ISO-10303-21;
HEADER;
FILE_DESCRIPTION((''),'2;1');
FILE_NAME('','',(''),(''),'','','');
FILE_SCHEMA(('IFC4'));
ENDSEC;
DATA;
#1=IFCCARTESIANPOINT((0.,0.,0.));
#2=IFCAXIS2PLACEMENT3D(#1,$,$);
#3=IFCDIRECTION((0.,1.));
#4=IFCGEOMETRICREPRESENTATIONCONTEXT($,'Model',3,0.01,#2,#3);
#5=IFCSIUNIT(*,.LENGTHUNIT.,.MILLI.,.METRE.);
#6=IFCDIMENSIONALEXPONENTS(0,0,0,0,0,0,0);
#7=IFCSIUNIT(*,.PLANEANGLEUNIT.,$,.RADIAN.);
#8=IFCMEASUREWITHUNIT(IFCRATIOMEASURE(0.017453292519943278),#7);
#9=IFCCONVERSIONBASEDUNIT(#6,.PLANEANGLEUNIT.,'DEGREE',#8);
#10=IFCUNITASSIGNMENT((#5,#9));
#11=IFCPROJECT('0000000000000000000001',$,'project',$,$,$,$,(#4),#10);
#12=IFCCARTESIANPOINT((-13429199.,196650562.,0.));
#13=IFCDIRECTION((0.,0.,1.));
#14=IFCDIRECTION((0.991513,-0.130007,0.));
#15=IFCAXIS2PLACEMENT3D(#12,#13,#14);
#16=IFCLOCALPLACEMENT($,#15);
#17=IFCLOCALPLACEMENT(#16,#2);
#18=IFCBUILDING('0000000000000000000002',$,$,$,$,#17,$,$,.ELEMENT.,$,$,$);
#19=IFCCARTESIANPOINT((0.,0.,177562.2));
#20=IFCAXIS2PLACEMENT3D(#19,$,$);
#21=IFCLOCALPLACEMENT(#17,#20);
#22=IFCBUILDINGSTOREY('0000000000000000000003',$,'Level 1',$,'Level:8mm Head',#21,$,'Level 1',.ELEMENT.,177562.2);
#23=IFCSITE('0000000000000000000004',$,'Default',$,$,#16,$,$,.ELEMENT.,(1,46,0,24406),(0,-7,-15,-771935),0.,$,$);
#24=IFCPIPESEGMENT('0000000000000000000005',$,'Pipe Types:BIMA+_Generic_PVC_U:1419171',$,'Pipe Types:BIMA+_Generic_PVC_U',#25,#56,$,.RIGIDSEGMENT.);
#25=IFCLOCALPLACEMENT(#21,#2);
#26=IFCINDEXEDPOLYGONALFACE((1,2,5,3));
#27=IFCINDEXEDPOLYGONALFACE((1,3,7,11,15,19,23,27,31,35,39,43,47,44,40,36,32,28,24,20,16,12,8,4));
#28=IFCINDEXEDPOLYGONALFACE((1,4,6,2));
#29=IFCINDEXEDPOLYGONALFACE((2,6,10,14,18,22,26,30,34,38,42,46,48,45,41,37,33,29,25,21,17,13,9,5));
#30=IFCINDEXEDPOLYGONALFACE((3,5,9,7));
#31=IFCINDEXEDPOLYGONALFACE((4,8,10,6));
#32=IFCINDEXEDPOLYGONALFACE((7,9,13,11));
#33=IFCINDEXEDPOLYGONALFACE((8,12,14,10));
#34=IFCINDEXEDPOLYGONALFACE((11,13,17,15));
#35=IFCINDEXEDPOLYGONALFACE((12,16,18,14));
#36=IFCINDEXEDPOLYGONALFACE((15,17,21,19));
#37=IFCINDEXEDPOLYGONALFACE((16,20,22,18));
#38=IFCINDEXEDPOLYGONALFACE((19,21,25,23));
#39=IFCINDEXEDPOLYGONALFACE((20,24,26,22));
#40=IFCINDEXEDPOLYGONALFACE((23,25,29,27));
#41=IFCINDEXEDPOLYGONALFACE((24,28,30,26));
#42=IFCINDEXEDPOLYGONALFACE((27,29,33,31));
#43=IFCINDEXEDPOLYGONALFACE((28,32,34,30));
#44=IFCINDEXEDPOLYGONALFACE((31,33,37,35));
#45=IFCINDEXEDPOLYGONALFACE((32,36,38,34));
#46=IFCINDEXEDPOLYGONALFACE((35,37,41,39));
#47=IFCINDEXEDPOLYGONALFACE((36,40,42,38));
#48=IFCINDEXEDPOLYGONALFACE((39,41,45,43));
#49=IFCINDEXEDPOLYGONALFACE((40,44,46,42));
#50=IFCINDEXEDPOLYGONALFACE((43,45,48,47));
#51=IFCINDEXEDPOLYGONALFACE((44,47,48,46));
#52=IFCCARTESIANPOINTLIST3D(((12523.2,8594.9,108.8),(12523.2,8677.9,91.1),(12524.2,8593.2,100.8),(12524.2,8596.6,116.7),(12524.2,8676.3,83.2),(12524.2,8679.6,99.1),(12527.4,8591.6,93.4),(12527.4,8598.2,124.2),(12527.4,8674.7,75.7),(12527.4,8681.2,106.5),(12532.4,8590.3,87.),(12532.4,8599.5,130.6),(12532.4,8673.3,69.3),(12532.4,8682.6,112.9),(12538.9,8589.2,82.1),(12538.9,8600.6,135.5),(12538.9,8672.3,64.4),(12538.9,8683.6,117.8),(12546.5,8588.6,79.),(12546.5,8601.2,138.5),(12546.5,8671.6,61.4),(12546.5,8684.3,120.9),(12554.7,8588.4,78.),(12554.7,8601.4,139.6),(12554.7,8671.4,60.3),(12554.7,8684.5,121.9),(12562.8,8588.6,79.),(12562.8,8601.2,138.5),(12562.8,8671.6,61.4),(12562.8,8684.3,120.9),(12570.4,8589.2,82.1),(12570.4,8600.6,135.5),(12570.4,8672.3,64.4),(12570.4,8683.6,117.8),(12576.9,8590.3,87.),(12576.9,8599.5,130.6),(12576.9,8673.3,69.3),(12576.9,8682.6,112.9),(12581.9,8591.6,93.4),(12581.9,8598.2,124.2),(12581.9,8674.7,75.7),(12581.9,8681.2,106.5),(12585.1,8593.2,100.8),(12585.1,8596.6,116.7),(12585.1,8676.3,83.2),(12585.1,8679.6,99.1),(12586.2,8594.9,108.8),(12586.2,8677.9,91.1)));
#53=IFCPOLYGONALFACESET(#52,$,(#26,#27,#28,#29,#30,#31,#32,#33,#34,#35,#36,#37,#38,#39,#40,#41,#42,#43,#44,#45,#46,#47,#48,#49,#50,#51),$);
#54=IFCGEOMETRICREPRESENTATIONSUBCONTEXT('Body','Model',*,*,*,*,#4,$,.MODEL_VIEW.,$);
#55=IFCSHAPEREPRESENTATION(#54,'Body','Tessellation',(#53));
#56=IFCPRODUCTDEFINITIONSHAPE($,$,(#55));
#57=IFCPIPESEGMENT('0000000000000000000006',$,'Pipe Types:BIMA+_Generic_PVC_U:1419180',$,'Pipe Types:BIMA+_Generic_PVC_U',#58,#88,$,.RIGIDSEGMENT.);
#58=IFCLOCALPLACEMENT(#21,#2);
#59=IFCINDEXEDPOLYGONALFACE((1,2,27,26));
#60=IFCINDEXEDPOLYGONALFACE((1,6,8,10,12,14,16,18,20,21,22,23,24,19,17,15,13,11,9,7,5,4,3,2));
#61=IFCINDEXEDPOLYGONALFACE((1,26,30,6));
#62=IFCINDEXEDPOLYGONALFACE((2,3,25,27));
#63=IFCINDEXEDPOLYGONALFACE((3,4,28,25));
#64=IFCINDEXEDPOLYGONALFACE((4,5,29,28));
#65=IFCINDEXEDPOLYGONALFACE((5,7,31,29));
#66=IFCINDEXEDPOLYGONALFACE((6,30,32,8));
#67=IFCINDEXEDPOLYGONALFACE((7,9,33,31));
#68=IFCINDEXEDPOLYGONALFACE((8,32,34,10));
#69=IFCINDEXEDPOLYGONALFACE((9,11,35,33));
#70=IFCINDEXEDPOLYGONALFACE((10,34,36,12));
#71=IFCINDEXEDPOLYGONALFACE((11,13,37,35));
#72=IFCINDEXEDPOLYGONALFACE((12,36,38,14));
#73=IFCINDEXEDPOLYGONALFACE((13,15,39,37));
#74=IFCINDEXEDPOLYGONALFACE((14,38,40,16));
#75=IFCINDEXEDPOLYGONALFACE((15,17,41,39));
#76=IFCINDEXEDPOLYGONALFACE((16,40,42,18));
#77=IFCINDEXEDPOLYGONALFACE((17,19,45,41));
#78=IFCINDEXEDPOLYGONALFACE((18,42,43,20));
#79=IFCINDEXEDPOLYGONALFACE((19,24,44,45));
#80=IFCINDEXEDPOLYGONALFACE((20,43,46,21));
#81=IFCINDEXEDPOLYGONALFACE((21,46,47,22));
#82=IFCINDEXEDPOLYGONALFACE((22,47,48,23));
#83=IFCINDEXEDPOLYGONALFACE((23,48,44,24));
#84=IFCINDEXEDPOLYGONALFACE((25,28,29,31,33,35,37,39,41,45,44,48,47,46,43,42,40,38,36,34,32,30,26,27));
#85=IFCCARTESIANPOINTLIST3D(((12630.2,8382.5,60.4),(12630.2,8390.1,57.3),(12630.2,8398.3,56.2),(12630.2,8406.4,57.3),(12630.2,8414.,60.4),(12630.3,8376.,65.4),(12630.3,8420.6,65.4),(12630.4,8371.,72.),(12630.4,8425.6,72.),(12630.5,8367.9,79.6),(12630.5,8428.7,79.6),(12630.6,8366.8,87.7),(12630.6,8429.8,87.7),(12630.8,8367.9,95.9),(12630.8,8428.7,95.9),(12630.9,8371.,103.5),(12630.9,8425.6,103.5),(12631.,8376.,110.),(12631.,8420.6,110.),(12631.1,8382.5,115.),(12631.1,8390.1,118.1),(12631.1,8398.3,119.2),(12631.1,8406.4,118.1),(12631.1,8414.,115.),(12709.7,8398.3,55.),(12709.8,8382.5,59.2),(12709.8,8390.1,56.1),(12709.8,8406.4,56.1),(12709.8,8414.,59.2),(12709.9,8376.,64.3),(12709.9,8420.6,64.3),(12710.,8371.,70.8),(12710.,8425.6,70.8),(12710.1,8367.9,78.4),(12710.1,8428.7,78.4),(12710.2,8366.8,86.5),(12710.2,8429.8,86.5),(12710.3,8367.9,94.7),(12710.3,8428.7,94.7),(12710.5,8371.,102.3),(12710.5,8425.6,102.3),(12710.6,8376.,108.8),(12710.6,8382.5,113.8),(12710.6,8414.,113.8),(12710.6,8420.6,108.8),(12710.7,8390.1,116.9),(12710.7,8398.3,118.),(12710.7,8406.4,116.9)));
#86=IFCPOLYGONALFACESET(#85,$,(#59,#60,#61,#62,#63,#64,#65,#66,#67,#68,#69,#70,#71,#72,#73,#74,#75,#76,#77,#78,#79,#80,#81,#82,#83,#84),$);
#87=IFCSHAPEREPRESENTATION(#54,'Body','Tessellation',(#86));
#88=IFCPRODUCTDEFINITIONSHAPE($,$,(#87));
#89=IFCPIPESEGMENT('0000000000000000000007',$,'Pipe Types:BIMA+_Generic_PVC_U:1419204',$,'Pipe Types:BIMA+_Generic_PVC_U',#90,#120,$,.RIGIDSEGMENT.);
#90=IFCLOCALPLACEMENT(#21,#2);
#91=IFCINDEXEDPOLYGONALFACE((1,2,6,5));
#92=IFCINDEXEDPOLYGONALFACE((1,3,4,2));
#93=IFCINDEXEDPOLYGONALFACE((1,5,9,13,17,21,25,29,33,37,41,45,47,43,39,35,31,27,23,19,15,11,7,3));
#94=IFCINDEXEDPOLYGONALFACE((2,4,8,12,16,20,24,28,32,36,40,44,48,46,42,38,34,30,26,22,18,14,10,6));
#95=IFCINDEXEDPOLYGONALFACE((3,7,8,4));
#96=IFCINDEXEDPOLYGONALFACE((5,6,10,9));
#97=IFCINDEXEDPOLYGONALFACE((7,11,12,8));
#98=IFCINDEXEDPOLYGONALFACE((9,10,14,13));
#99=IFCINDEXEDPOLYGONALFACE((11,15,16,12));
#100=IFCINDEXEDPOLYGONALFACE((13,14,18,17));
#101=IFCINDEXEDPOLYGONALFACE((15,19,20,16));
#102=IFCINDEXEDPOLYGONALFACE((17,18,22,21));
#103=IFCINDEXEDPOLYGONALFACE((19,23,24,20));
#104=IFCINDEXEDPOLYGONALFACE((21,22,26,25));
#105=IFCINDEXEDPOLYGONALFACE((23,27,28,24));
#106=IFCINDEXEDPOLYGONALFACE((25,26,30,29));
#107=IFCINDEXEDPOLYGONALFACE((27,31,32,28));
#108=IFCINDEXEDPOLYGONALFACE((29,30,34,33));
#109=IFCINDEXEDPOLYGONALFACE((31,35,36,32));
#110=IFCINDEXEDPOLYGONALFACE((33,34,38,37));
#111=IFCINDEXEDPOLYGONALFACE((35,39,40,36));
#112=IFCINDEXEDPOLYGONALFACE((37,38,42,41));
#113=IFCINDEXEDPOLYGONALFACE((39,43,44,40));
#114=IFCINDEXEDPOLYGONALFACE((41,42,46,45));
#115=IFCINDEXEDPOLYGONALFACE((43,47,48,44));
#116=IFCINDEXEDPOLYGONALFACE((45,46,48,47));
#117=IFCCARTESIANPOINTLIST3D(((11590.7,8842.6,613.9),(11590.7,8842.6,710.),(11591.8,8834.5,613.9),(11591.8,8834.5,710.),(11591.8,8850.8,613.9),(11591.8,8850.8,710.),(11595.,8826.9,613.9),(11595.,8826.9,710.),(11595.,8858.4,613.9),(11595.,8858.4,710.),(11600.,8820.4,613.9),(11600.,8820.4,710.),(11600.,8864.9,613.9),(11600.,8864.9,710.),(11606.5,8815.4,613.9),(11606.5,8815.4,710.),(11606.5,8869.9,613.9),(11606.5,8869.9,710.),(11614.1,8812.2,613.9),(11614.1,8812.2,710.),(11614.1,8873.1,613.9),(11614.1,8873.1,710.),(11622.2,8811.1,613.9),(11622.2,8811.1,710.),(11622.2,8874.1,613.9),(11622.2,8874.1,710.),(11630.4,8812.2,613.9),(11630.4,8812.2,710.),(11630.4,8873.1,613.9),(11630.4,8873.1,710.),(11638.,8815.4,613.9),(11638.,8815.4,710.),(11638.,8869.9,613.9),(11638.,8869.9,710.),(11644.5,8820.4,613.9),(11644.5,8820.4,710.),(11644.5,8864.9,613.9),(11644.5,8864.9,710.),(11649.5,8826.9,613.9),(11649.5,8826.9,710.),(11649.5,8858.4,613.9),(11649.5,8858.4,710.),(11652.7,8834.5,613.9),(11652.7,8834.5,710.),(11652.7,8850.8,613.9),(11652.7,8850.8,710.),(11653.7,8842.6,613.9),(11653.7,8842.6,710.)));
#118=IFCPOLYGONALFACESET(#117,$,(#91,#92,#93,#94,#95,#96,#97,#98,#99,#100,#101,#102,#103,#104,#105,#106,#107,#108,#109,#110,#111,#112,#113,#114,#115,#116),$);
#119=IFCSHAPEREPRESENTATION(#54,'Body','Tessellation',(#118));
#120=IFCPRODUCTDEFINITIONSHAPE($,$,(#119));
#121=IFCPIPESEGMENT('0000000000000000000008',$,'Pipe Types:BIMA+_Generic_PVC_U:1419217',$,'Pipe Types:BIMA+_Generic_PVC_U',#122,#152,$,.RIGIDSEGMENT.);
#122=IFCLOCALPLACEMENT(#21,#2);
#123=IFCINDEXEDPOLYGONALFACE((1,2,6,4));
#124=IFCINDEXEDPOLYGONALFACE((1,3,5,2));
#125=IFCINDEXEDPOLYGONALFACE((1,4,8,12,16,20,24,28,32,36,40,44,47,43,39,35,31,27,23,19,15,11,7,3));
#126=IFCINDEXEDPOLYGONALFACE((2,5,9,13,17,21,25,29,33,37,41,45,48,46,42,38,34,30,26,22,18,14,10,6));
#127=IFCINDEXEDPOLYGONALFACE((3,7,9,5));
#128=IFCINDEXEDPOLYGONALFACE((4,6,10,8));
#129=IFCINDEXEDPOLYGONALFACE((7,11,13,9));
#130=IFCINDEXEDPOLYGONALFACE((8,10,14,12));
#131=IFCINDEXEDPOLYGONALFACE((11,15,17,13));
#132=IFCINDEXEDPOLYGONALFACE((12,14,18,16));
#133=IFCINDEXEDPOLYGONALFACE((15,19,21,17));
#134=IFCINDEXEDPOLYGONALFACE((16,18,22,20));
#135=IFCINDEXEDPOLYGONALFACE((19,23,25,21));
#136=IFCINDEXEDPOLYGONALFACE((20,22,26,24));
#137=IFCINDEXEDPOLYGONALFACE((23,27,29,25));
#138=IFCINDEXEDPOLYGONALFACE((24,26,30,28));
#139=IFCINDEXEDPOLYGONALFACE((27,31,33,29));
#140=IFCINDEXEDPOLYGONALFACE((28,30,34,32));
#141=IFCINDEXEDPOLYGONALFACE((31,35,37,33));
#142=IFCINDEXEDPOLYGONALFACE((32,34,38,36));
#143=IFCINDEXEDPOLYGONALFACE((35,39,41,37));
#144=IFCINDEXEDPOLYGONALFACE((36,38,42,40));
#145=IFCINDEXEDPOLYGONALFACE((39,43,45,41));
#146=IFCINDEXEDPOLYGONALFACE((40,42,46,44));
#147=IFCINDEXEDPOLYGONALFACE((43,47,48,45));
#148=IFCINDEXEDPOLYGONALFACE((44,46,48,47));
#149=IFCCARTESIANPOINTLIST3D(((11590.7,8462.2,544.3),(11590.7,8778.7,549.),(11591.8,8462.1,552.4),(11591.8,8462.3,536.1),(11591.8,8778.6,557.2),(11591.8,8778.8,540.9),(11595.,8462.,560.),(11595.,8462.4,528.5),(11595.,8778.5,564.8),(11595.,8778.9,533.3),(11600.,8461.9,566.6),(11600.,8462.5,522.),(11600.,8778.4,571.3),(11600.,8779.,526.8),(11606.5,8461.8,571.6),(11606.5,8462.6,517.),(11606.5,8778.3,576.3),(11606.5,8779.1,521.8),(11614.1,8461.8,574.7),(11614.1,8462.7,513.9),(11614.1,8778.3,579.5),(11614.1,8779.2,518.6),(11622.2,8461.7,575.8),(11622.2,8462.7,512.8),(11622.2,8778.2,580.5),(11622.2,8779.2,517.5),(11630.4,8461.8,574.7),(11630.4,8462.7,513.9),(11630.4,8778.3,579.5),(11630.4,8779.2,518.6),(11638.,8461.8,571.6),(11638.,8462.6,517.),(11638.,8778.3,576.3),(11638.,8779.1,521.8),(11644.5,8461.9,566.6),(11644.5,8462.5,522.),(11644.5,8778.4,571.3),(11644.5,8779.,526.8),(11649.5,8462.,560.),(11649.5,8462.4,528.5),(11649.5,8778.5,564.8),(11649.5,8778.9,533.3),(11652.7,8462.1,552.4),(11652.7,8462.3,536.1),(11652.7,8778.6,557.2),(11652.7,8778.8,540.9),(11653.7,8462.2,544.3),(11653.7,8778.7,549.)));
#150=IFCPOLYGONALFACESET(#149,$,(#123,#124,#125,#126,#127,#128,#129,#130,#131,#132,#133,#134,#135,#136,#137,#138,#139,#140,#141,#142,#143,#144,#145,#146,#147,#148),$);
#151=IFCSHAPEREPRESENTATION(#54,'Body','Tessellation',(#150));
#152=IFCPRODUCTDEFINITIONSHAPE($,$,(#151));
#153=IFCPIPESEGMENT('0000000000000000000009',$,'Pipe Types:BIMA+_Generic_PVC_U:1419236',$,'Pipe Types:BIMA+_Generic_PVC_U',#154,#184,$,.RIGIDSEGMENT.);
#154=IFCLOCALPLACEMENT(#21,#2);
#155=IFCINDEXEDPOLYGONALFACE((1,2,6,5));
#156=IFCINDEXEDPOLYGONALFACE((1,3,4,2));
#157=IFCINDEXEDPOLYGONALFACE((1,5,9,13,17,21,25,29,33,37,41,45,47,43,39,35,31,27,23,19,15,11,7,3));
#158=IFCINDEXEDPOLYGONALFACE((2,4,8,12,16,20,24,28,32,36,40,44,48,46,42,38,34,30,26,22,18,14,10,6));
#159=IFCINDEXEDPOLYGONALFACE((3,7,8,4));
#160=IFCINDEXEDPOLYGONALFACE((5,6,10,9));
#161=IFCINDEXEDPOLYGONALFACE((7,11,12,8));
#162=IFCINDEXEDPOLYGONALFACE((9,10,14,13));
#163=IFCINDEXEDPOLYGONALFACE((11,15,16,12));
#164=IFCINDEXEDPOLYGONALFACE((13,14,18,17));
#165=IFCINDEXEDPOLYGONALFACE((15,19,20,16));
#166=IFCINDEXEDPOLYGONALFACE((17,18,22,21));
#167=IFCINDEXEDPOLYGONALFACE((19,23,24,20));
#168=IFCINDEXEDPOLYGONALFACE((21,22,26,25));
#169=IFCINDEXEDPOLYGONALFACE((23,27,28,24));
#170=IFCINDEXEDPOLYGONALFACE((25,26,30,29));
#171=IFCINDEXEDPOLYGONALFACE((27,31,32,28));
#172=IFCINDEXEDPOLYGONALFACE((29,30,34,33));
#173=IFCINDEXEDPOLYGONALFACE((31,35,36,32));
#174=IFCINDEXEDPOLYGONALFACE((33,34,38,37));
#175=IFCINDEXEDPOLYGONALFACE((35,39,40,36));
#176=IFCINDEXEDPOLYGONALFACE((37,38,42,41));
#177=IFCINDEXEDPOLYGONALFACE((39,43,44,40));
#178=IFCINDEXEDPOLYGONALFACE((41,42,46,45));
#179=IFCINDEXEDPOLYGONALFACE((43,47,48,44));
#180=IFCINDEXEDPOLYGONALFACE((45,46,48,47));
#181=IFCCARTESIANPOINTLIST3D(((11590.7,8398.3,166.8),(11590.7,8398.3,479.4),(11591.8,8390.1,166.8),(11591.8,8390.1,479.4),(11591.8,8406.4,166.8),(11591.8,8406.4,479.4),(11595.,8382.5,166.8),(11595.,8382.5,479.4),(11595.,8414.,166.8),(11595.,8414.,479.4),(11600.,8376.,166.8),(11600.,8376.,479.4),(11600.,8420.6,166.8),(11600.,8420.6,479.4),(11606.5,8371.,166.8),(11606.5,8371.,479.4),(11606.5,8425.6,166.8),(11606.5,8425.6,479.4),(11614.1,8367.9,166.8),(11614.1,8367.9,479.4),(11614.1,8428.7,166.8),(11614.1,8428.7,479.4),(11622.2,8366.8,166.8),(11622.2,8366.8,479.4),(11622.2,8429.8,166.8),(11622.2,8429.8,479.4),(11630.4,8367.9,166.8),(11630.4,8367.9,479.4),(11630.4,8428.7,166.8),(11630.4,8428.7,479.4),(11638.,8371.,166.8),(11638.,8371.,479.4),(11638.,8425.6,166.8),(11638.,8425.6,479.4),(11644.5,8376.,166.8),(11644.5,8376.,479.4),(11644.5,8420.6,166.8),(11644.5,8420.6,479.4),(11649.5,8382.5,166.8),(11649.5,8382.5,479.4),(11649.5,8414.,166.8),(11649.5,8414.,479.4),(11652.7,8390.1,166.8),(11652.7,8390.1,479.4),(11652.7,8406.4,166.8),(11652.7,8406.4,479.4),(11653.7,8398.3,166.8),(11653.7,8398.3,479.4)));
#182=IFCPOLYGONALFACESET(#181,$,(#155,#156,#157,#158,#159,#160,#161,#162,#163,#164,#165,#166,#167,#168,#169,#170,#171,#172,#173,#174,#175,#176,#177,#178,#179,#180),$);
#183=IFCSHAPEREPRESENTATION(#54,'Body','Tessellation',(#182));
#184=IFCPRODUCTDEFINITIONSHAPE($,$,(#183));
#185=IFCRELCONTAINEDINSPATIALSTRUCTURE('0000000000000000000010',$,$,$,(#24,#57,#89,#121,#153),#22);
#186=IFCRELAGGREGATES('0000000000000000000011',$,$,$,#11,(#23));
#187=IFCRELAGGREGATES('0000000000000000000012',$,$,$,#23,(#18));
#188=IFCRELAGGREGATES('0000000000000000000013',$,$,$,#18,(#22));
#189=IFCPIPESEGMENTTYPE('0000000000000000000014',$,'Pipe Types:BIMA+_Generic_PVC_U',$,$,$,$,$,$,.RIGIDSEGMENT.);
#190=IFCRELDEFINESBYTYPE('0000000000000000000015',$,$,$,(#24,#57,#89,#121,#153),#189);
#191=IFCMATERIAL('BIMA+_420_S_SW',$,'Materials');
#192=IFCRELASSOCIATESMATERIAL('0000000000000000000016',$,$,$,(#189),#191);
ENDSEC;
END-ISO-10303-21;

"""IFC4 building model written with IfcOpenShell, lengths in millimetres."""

from ifc_helpers import new_model, entity, si_unit, converted_unit, direction, frame, origin, place, context, subcontext, project, spatial, arc, indexed_curve, outline, extrude, material, type_object, element, save


model = new_model("IFC4")

# Units and contexts
model_context = context("Model", 3, precision=0.01, world=origin(), true_north=direction((0.0, 1.0)))
body_context = subcontext(model_context, "Body", "Model", "MODEL_VIEW")
ifc_project = project(units=[si_unit("LENGTHUNIT", "METRE", prefix="MILLI"), converted_unit("PLANEANGLEUNIT", "DEGREE", entity("IfcRatioMeasure", 0.017453292519943278), si_unit("PLANEANGLEUNIT", "RADIAN"), dimensions=[0, 0, 0, 0, 0, 0, 0])], contexts=[model_context])

# Site, building, storey
site_placement = place(None, frame((-13429199.0, 196650562.0, 0.0), z_axis=(0.0, 0.0, 1.0), x_axis=(0.991513, -0.130007, 0.0)))
site = spatial("IfcSite", under=ifc_project, at=site_placement, Name="Default", CompositionType="ELEMENT", RefLatitude=(1, 46, 0, 24406), RefLongitude=(0, -7, -15, -771935), RefElevation=0.0)
building_placement = place(site_placement, origin())
building = spatial("IfcBuilding", under=site, at=building_placement, CompositionType="ELEMENT")
storey_placement = place(building_placement, frame((0.0, 0.0, 177562.2)))
storey = spatial("IfcBuildingStorey", under=building, at=storey_placement, Name="Level 1", ObjectType="Level:8mm Head", LongName="Level 1", CompositionType="ELEMENT", Elevation=177562.2)

# Pipe segments
ifc_material_1 = material(Name="BIMA+_420_S_SW", Category="Materials")
pipe_segment_type_1 = type_object("IfcPipeSegmentType", Name="Pipe Types:BIMA+_Generic_PVC_U", PredefinedType="RIGIDSEGMENT", material=ifc_material_1)
pipe_segment_1_placement = place(storey_placement, frame((12521.6, 8586.8, 141.2)))
element("IfcPipeSegment", 1, at=pipe_segment_1_placement, inside=storey, type_object=pipe_segment_type_1, Name="Pipe Types:BIMA+_Generic_PVC_U:1419171", ObjectType="Pipe Types:BIMA+_Generic_PVC_U", PredefinedType="RIGIDSEGMENT", context=body_context, shape_type="SweptSolid", body=[
    extrude(outline(indexed_curve([(31.5, 0.0), (22.3, 22.3), (0.0, 31.5), (-22.3, 22.3), (-31.5, 0.0), (-22.3, -22.3), (0.0, -31.5), (22.3, -22.3)], segments=[arc(1, 2, 3), arc(3, 4, 5), arc(5, 6, 7), arc(7, 8, 1)], self_intersect=False)), frame((33.1, 91.2, -50.0), z_axis=(-0.000061, -0.978185, 0.207737), x_axis=(-1.0, 0.000062, 0.0)), (0.0, 0.0, 1.0), 84.9),
])
pipe_segment_2_placement = place(storey_placement, frame((12628.6, 8365.2, 120.8)))
element("IfcPipeSegment", 2, at=pipe_segment_2_placement, inside=storey, type_object=pipe_segment_type_1, Name="Pipe Types:BIMA+_Generic_PVC_U:1419180", ObjectType="Pipe Types:BIMA+_Generic_PVC_U", PredefinedType="RIGIDSEGMENT", context=body_context, shape_type="SweptSolid", body=[
    extrude(outline(indexed_curve([(31.5, 0.0), (22.3, 22.3), (0.0, 31.5), (-22.3, 22.3), (-31.5, 0.0), (-22.3, -22.3), (0.0, -31.5), (22.3, -22.3)], segments=[arc(1, 2, 3), arc(3, 4, 5), arc(5, 6, 7), arc(7, 8, 1)], self_intersect=False)), frame((2.1, 33.1, -33.1), z_axis=(0.999888, 0.0, -0.014998), x_axis=(0.0, -1.0, 0.0)), (0.0, 0.0, 1.0), 79.6),
])
pipe_segment_3_placement = place(storey_placement, frame((11589.1, 8809.5, 710.0)))
element("IfcPipeSegment", 3, at=pipe_segment_3_placement, inside=storey, type_object=pipe_segment_type_1, Name="Pipe Types:BIMA+_Generic_PVC_U:1419204", ObjectType="Pipe Types:BIMA+_Generic_PVC_U", PredefinedType="RIGIDSEGMENT", context=body_context, shape_type="SweptSolid", body=[
    extrude(outline(indexed_curve([(31.5, 0.0), (22.3, 22.3), (0.0, 31.5), (-22.3, 22.3), (-31.5, 0.0), (-22.3, -22.3), (0.0, -31.5), (22.3, -22.3)], segments=[arc(1, 2, 3), arc(3, 4, 5), arc(5, 6, 7), arc(7, 8, 1)], self_intersect=False)), frame((33.1, 33.1, -96.1)), (0.0, 0.0, 1.0), 96.1),
])
pipe_segment_4_placement = place(storey_placement, frame((11589.1, 8460.1, 511.2)))
element("IfcPipeSegment", 4, at=pipe_segment_4_placement, inside=storey, type_object=pipe_segment_type_1, Name="Pipe Types:BIMA+_Generic_PVC_U:1419217", ObjectType="Pipe Types:BIMA+_Generic_PVC_U", PredefinedType="RIGIDSEGMENT", context=body_context, shape_type="SweptSolid", body=[
    extrude(outline(indexed_curve([(31.5, 0.0), (22.3, 22.3), (0.0, 31.5), (-22.3, 22.3), (-31.5, 0.0), (-22.3, -22.3), (0.0, -31.5), (22.3, -22.3)], segments=[arc(1, 2, 3), arc(3, 4, 5), arc(5, 6, 7), arc(7, 8, 1)], self_intersect=False)), frame((33.1, 2.1, 33.1), z_axis=(0.0, 0.999888, 0.014998), x_axis=(-1.0, 0.0, 0.0)), (0.0, 0.0, 1.0), 316.5),
])
pipe_segment_5_placement = place(storey_placement, frame((11589.1, 8365.2, 166.8)))
element("IfcPipeSegment", 5, at=pipe_segment_5_placement, inside=storey, type_object=pipe_segment_type_1, Name="Pipe Types:BIMA+_Generic_PVC_U:1419236", ObjectType="Pipe Types:BIMA+_Generic_PVC_U", PredefinedType="RIGIDSEGMENT", context=body_context, shape_type="SweptSolid", body=[
    extrude(outline(indexed_curve([(31.5, 0.0), (22.3, 22.3), (0.0, 31.5), (-22.3, 22.3), (-31.5, 0.0), (-22.3, -22.3), (0.0, -31.5), (22.3, -22.3)], segments=[arc(1, 2, 3), arc(3, 4, 5), arc(5, 6, 7), arc(7, 8, 1)], self_intersect=False)), frame((33.1, 33.1, 0.0)), (0.0, 0.0, 1.0), 312.6),
])

save(model, "model.ifc")
